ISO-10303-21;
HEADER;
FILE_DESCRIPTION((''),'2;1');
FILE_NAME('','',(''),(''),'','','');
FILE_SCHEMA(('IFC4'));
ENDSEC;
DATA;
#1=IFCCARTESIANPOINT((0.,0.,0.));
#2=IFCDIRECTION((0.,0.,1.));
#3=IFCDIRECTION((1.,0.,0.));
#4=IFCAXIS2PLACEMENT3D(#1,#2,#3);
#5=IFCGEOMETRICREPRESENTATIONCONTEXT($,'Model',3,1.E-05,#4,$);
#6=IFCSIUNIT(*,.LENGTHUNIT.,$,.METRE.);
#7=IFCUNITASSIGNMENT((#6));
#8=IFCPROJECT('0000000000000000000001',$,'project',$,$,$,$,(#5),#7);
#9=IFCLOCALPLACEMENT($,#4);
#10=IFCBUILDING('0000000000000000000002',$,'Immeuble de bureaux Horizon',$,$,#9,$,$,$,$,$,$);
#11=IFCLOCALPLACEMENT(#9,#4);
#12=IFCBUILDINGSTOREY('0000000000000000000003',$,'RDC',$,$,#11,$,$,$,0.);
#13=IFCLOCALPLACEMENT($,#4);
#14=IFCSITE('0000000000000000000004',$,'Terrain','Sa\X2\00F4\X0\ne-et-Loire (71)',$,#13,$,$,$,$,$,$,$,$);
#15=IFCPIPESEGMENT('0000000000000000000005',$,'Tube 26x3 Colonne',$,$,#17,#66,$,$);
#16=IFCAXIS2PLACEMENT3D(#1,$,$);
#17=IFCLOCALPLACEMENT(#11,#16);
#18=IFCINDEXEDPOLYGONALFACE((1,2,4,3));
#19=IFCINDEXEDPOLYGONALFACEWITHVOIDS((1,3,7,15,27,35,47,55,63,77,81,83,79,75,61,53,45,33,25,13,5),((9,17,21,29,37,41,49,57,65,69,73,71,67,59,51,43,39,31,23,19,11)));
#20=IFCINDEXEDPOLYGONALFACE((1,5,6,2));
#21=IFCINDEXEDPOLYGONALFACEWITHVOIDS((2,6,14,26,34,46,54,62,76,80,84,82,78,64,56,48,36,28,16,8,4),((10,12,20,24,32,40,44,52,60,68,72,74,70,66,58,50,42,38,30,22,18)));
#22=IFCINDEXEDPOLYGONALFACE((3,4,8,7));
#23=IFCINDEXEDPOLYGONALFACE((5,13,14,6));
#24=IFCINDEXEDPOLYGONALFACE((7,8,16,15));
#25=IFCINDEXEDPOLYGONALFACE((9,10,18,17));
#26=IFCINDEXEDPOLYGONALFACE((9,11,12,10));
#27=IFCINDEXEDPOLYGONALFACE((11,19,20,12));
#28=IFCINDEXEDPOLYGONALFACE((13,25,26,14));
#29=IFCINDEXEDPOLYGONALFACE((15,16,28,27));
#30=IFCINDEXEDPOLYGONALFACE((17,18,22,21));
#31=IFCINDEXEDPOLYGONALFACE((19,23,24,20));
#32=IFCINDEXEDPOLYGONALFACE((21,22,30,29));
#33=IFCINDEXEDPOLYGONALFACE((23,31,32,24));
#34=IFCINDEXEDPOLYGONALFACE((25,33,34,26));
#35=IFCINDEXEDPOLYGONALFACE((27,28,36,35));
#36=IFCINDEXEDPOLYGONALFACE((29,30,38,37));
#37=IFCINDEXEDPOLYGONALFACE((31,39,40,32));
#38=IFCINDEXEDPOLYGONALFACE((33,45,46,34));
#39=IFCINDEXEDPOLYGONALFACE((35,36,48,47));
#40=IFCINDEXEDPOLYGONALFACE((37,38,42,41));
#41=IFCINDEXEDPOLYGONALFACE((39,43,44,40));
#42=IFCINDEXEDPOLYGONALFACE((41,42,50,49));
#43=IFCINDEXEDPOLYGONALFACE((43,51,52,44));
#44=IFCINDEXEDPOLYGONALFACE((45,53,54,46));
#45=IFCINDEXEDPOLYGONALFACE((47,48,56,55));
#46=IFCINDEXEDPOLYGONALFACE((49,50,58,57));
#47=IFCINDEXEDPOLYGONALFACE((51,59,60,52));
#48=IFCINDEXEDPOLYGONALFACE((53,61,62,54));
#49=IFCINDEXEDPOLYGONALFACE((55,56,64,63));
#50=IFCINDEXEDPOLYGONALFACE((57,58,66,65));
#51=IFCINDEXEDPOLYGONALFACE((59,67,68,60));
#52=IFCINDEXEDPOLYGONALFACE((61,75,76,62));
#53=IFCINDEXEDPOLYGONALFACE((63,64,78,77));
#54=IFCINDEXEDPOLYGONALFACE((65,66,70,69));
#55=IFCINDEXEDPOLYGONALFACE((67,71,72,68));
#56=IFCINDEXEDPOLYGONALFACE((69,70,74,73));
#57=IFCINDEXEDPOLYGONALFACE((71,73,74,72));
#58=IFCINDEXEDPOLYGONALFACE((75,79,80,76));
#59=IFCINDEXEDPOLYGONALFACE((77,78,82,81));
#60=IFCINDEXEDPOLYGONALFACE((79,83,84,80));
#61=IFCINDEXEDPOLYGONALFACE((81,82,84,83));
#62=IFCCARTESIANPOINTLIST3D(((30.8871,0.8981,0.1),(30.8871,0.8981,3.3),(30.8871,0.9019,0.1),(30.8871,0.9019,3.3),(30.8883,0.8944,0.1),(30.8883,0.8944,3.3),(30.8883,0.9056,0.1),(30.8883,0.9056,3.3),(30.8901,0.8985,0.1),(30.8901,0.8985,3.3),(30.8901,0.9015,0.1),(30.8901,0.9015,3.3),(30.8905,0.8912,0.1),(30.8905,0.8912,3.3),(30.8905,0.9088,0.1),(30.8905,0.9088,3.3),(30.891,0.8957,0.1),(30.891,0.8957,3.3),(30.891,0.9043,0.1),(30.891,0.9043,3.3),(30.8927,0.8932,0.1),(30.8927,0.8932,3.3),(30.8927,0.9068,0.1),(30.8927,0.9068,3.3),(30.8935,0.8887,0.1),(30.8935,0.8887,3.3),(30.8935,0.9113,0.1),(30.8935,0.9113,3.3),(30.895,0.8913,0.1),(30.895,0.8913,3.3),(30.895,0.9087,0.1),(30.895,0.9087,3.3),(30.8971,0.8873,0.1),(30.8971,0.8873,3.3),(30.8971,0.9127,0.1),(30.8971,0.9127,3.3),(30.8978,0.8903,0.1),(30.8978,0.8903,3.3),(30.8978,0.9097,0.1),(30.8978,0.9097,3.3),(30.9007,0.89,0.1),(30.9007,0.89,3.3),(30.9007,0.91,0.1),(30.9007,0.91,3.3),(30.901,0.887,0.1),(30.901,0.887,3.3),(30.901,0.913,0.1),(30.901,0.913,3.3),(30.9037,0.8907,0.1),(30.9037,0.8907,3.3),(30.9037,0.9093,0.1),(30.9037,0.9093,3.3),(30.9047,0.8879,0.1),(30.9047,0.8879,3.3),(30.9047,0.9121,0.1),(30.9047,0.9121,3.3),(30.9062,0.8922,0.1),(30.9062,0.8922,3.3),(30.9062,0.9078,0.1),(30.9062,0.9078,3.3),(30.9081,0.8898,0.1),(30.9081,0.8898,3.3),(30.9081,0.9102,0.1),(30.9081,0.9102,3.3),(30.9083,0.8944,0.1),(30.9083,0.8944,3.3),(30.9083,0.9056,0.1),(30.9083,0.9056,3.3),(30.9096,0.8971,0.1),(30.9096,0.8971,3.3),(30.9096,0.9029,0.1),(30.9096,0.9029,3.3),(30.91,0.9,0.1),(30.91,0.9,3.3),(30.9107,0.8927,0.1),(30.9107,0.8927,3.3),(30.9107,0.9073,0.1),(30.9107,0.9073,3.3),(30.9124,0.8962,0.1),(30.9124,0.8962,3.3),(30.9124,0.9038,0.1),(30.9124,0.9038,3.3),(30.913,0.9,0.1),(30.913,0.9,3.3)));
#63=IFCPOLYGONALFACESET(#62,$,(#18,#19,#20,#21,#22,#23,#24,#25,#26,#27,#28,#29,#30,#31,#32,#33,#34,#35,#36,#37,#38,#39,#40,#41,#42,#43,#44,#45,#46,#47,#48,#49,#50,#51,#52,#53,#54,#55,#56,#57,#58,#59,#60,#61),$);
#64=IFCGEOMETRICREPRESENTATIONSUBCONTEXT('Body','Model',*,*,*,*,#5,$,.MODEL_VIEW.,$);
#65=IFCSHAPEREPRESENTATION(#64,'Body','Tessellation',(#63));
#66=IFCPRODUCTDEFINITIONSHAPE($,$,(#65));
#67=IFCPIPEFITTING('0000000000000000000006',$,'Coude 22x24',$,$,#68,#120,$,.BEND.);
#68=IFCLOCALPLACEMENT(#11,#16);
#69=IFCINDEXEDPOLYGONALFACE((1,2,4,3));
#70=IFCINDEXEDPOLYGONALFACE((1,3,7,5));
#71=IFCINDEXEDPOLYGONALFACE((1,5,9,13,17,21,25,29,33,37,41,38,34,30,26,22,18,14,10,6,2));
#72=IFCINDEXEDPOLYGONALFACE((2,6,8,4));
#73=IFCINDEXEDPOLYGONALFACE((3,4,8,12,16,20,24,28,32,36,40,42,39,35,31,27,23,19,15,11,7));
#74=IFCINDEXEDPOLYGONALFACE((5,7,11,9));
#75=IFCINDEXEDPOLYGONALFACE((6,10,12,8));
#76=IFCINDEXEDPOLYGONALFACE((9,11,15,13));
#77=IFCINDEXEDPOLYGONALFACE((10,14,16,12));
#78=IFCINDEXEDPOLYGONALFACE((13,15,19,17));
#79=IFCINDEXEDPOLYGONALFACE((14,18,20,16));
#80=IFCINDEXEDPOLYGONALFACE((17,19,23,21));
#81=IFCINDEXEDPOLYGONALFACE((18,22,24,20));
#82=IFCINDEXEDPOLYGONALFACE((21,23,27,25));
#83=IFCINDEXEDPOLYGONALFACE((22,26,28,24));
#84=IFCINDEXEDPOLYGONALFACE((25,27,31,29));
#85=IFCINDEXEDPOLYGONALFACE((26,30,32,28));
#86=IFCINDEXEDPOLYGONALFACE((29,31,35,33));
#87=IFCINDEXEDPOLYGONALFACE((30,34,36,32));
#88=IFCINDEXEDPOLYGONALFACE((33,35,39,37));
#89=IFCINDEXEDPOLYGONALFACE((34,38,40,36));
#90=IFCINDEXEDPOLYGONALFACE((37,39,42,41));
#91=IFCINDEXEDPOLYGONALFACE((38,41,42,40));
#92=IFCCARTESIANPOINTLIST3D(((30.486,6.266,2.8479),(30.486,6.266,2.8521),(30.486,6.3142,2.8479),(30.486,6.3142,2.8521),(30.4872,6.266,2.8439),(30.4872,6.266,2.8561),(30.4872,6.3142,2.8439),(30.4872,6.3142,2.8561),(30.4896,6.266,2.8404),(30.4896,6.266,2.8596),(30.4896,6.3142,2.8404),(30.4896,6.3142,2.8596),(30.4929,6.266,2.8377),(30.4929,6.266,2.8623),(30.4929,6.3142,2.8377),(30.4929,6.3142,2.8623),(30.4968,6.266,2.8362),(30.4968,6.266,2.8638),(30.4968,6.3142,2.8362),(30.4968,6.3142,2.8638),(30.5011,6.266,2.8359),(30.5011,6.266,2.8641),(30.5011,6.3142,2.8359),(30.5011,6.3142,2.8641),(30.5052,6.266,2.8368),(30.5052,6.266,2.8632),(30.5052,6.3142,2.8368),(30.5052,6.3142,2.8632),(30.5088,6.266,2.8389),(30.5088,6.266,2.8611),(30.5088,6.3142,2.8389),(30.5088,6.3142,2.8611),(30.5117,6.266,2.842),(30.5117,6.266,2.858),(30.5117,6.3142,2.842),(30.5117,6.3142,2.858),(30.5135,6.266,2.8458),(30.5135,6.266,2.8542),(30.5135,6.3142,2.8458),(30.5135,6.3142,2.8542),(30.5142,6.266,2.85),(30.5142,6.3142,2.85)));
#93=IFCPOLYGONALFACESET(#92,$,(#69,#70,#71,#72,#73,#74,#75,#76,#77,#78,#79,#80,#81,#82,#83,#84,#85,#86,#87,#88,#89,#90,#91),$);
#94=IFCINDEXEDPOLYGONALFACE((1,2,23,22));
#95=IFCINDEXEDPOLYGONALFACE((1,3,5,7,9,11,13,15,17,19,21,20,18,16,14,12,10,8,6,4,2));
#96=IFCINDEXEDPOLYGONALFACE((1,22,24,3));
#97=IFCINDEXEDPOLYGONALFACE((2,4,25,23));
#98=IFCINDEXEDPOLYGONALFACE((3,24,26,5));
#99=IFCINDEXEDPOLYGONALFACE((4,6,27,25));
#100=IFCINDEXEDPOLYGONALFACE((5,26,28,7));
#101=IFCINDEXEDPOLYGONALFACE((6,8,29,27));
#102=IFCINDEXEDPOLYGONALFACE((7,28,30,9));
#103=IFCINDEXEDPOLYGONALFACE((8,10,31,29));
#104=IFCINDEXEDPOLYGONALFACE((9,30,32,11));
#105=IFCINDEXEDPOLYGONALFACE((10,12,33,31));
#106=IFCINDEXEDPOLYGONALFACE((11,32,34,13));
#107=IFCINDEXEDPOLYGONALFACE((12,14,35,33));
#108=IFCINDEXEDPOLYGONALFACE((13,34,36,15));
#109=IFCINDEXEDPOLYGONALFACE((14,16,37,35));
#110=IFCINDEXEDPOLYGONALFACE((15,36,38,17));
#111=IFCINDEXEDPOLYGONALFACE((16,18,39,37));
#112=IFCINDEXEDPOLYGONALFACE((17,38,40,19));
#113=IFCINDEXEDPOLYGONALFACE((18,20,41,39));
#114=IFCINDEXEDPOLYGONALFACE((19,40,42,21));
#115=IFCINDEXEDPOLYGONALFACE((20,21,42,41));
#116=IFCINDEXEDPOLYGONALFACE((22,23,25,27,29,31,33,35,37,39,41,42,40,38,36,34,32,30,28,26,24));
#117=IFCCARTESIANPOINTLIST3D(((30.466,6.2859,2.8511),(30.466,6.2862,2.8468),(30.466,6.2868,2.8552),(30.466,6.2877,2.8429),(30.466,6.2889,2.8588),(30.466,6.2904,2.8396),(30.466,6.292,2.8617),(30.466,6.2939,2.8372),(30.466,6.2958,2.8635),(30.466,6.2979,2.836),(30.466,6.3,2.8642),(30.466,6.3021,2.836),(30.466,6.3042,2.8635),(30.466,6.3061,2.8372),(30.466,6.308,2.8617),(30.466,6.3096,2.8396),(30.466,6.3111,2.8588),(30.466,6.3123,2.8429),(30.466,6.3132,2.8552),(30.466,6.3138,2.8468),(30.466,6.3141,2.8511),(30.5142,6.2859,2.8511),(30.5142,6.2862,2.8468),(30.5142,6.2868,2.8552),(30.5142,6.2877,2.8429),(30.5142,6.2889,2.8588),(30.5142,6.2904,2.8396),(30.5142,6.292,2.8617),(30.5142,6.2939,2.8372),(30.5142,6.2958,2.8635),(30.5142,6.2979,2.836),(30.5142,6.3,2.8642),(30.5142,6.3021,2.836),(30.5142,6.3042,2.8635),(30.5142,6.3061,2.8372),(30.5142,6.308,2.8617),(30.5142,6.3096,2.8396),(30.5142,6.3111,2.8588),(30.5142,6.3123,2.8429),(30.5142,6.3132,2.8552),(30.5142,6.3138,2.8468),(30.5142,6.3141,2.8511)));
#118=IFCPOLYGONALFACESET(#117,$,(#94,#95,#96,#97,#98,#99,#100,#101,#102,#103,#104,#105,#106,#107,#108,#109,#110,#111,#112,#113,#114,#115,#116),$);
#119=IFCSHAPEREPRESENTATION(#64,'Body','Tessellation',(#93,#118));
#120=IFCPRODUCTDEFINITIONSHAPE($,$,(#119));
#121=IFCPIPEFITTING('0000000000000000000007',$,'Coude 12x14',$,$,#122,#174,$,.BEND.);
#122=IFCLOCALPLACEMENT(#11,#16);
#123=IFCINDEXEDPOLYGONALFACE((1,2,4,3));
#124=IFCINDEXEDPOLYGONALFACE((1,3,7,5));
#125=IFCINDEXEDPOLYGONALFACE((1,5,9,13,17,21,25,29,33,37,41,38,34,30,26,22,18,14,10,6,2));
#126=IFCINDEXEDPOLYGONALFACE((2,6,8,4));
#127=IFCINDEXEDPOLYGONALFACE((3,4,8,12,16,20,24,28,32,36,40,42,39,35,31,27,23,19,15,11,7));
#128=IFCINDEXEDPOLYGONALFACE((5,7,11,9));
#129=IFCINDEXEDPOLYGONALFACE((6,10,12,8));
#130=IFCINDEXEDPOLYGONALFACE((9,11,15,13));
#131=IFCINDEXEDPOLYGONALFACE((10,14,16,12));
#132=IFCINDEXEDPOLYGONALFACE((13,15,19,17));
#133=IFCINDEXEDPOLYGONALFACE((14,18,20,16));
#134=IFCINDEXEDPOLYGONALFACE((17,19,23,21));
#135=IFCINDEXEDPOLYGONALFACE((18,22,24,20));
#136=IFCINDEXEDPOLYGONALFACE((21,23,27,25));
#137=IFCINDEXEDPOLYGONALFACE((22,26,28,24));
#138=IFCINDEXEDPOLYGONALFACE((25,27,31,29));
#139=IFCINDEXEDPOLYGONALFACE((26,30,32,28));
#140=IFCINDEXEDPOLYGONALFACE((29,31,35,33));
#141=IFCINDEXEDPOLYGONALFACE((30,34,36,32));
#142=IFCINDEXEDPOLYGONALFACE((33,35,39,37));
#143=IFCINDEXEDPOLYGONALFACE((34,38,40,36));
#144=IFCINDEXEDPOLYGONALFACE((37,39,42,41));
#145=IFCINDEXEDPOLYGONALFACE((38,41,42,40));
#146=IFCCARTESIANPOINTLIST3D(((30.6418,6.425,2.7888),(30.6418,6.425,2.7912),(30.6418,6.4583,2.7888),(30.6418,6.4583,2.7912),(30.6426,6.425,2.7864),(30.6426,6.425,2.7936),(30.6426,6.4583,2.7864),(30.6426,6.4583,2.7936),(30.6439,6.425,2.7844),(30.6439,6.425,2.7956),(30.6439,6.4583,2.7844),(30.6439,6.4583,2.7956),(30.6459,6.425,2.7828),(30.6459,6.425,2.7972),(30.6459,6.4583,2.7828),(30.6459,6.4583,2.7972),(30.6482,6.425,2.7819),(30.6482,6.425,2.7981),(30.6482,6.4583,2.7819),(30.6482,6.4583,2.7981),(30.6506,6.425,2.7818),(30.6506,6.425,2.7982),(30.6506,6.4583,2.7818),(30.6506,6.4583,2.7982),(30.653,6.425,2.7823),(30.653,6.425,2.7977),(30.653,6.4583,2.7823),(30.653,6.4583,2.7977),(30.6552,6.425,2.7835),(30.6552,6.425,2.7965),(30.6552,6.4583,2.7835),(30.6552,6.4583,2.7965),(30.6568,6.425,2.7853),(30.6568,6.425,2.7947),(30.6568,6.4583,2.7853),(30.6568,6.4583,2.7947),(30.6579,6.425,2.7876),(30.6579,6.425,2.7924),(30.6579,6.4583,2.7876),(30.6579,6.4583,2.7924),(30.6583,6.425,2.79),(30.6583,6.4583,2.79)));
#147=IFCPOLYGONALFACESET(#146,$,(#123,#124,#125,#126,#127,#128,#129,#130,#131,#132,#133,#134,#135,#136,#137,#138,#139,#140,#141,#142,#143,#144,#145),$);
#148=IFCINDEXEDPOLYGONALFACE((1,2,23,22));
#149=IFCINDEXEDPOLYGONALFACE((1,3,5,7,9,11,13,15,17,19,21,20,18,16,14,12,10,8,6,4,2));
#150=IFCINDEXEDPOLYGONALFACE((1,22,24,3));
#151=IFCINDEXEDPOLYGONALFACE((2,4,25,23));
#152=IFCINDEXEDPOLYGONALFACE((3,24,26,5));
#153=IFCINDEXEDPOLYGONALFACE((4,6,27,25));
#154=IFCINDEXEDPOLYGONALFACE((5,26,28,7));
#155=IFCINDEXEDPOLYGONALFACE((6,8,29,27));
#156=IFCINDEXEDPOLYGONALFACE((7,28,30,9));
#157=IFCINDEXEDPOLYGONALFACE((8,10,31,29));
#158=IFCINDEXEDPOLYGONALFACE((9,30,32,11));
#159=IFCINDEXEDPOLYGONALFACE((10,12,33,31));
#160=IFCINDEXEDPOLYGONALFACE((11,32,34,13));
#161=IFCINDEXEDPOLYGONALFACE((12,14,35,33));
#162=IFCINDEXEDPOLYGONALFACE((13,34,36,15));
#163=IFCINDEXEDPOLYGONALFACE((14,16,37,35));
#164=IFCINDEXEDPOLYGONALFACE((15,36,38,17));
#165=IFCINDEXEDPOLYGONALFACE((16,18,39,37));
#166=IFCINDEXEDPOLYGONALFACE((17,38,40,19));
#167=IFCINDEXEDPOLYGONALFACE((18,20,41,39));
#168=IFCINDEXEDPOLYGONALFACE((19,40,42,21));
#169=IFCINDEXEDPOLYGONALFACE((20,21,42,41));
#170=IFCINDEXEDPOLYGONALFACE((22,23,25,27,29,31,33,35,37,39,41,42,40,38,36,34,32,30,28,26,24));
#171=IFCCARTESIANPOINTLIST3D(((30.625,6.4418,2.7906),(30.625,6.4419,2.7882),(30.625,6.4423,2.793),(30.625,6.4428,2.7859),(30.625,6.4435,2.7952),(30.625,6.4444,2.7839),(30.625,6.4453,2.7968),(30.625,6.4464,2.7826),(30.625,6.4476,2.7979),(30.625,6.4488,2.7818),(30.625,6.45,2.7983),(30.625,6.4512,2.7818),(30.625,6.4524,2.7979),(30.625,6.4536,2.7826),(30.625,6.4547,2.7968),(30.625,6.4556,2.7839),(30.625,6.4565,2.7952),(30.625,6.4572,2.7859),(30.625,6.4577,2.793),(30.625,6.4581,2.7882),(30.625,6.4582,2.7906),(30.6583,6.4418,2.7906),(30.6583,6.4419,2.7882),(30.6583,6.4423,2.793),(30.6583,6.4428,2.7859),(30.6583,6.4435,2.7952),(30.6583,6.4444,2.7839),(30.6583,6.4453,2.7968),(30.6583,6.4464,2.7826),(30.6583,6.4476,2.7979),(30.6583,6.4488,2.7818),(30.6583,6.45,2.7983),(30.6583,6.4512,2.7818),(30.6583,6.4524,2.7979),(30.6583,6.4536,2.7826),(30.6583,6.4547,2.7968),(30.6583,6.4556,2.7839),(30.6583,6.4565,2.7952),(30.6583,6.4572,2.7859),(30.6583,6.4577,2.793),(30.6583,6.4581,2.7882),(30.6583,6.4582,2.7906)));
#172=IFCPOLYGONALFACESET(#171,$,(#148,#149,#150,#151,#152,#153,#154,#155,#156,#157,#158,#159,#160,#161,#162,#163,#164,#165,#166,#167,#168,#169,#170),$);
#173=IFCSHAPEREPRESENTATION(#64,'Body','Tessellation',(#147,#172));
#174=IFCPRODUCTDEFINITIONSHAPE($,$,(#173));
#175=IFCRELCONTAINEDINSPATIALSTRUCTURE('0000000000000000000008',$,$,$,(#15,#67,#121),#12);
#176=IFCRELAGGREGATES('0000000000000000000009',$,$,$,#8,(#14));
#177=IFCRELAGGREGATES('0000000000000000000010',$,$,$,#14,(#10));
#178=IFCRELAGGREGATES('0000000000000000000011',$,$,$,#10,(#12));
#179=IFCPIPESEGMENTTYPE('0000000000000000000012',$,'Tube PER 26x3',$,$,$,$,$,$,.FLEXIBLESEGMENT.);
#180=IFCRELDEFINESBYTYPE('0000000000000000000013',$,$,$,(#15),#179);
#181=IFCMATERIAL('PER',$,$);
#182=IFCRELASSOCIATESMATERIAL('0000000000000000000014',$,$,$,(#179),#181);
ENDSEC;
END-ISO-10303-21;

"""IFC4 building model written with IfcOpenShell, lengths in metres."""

from ifc_helpers import new_model, si_unit, frame, origin_with_axes, place, context, subcontext, project, spatial, circle, hollow_circle, extrude, material, type_object, element, save


model = new_model("IFC4")

# Units and contexts
model_context = context("Model", 3, precision=1e-05, world=origin_with_axes())
body_context = subcontext(model_context, "Body", "Model", "MODEL_VIEW")
ifc_project = project(units=[si_unit("LENGTHUNIT", "METRE")], contexts=[model_context])

# Site, building, storey
site_placement = place(None, origin_with_axes())
site = spatial("IfcSite", under=ifc_project, at=site_placement, Name="Terrain", Description="Saône-et-Loire (71)")
building_placement = place(None, origin_with_axes())
building = spatial("IfcBuilding", under=site, at=building_placement, Name="Immeuble de bureaux Horizon")
storey_placement = place(building_placement, origin_with_axes())
storey = spatial("IfcBuildingStorey", under=building, at=storey_placement, Name="RDC", Elevation=0.0)

# Shared definitions
ifc_material_1 = material(Name="PER")

# Pipe segment
pipe_segment_type_1 = type_object("IfcPipeSegmentType", Name="Tube PER 26x3", PredefinedType="FLEXIBLESEGMENT", material=ifc_material_1)
pipe_segment_1_placement = place(storey_placement, frame((30.9, 0.9, 0.1), z_axis=(0.0, 0.0, 1.0), x_axis=(1.0, 0.0, 0.0)))
element("IfcPipeSegment", 1, at=pipe_segment_1_placement, inside=storey, type_object=pipe_segment_type_1, Name="Tube 26x3 Colonne", context=body_context, shape_type="SweptSolid", body=[
    extrude(hollow_circle(Radius=0.013, WallThickness=0.003), origin_with_axes(), (0.0, 0.0, 1.0), 3.2),
])

# Pipe fittings
pipe_fitting_1_placement = place(storey_placement, frame((30.5, 6.3, 2.85), z_axis=(0.0, 0.0, 1.0), x_axis=(1.0, 0.0, 0.0)))
element("IfcPipeFitting", 2, at=pipe_fitting_1_placement, inside=storey, Name="Coude 22x24", PredefinedType="BEND", context=body_context, shape_type="SweptSolid", body=[
    extrude(circle(Radius=0.0142), frame((0.0, 0.0142, 0.0), z_axis=(0.0, -1.0, 0.0), x_axis=(1.0, 0.0, 0.0)), (0.0, 0.0, 1.0), 0.0481),
    extrude(circle(Radius=0.0142), frame((0.0142, 0.0, 0.0), z_axis=(-1.0, 0.0, 0.0), x_axis=(0.0, 0.0, 1.0)), (0.0, 0.0, 1.0), 0.0481),
])
pipe_fitting_2_placement = place(storey_placement, frame((30.65, 6.45, 2.79), z_axis=(0.0, 0.0, 1.0), x_axis=(1.0, 0.0, 0.0)))
element("IfcPipeFitting", 3, at=pipe_fitting_2_placement, inside=storey, Name="Coude 12x14", PredefinedType="BEND", context=body_context, shape_type="SweptSolid", body=[
    extrude(circle(Radius=0.0083), frame((0.0, 0.0083, 0.0), z_axis=(0.0, -1.0, 0.0), x_axis=(1.0, 0.0, 0.0)), (0.0, 0.0, 1.0), 0.0333),
    extrude(circle(Radius=0.0083), frame((0.0083, 0.0, 0.0), z_axis=(-1.0, 0.0, 0.0), x_axis=(0.0, 0.0, 1.0)), (0.0, 0.0, 1.0), 0.0333),
])

save(model, "model.ifc")
